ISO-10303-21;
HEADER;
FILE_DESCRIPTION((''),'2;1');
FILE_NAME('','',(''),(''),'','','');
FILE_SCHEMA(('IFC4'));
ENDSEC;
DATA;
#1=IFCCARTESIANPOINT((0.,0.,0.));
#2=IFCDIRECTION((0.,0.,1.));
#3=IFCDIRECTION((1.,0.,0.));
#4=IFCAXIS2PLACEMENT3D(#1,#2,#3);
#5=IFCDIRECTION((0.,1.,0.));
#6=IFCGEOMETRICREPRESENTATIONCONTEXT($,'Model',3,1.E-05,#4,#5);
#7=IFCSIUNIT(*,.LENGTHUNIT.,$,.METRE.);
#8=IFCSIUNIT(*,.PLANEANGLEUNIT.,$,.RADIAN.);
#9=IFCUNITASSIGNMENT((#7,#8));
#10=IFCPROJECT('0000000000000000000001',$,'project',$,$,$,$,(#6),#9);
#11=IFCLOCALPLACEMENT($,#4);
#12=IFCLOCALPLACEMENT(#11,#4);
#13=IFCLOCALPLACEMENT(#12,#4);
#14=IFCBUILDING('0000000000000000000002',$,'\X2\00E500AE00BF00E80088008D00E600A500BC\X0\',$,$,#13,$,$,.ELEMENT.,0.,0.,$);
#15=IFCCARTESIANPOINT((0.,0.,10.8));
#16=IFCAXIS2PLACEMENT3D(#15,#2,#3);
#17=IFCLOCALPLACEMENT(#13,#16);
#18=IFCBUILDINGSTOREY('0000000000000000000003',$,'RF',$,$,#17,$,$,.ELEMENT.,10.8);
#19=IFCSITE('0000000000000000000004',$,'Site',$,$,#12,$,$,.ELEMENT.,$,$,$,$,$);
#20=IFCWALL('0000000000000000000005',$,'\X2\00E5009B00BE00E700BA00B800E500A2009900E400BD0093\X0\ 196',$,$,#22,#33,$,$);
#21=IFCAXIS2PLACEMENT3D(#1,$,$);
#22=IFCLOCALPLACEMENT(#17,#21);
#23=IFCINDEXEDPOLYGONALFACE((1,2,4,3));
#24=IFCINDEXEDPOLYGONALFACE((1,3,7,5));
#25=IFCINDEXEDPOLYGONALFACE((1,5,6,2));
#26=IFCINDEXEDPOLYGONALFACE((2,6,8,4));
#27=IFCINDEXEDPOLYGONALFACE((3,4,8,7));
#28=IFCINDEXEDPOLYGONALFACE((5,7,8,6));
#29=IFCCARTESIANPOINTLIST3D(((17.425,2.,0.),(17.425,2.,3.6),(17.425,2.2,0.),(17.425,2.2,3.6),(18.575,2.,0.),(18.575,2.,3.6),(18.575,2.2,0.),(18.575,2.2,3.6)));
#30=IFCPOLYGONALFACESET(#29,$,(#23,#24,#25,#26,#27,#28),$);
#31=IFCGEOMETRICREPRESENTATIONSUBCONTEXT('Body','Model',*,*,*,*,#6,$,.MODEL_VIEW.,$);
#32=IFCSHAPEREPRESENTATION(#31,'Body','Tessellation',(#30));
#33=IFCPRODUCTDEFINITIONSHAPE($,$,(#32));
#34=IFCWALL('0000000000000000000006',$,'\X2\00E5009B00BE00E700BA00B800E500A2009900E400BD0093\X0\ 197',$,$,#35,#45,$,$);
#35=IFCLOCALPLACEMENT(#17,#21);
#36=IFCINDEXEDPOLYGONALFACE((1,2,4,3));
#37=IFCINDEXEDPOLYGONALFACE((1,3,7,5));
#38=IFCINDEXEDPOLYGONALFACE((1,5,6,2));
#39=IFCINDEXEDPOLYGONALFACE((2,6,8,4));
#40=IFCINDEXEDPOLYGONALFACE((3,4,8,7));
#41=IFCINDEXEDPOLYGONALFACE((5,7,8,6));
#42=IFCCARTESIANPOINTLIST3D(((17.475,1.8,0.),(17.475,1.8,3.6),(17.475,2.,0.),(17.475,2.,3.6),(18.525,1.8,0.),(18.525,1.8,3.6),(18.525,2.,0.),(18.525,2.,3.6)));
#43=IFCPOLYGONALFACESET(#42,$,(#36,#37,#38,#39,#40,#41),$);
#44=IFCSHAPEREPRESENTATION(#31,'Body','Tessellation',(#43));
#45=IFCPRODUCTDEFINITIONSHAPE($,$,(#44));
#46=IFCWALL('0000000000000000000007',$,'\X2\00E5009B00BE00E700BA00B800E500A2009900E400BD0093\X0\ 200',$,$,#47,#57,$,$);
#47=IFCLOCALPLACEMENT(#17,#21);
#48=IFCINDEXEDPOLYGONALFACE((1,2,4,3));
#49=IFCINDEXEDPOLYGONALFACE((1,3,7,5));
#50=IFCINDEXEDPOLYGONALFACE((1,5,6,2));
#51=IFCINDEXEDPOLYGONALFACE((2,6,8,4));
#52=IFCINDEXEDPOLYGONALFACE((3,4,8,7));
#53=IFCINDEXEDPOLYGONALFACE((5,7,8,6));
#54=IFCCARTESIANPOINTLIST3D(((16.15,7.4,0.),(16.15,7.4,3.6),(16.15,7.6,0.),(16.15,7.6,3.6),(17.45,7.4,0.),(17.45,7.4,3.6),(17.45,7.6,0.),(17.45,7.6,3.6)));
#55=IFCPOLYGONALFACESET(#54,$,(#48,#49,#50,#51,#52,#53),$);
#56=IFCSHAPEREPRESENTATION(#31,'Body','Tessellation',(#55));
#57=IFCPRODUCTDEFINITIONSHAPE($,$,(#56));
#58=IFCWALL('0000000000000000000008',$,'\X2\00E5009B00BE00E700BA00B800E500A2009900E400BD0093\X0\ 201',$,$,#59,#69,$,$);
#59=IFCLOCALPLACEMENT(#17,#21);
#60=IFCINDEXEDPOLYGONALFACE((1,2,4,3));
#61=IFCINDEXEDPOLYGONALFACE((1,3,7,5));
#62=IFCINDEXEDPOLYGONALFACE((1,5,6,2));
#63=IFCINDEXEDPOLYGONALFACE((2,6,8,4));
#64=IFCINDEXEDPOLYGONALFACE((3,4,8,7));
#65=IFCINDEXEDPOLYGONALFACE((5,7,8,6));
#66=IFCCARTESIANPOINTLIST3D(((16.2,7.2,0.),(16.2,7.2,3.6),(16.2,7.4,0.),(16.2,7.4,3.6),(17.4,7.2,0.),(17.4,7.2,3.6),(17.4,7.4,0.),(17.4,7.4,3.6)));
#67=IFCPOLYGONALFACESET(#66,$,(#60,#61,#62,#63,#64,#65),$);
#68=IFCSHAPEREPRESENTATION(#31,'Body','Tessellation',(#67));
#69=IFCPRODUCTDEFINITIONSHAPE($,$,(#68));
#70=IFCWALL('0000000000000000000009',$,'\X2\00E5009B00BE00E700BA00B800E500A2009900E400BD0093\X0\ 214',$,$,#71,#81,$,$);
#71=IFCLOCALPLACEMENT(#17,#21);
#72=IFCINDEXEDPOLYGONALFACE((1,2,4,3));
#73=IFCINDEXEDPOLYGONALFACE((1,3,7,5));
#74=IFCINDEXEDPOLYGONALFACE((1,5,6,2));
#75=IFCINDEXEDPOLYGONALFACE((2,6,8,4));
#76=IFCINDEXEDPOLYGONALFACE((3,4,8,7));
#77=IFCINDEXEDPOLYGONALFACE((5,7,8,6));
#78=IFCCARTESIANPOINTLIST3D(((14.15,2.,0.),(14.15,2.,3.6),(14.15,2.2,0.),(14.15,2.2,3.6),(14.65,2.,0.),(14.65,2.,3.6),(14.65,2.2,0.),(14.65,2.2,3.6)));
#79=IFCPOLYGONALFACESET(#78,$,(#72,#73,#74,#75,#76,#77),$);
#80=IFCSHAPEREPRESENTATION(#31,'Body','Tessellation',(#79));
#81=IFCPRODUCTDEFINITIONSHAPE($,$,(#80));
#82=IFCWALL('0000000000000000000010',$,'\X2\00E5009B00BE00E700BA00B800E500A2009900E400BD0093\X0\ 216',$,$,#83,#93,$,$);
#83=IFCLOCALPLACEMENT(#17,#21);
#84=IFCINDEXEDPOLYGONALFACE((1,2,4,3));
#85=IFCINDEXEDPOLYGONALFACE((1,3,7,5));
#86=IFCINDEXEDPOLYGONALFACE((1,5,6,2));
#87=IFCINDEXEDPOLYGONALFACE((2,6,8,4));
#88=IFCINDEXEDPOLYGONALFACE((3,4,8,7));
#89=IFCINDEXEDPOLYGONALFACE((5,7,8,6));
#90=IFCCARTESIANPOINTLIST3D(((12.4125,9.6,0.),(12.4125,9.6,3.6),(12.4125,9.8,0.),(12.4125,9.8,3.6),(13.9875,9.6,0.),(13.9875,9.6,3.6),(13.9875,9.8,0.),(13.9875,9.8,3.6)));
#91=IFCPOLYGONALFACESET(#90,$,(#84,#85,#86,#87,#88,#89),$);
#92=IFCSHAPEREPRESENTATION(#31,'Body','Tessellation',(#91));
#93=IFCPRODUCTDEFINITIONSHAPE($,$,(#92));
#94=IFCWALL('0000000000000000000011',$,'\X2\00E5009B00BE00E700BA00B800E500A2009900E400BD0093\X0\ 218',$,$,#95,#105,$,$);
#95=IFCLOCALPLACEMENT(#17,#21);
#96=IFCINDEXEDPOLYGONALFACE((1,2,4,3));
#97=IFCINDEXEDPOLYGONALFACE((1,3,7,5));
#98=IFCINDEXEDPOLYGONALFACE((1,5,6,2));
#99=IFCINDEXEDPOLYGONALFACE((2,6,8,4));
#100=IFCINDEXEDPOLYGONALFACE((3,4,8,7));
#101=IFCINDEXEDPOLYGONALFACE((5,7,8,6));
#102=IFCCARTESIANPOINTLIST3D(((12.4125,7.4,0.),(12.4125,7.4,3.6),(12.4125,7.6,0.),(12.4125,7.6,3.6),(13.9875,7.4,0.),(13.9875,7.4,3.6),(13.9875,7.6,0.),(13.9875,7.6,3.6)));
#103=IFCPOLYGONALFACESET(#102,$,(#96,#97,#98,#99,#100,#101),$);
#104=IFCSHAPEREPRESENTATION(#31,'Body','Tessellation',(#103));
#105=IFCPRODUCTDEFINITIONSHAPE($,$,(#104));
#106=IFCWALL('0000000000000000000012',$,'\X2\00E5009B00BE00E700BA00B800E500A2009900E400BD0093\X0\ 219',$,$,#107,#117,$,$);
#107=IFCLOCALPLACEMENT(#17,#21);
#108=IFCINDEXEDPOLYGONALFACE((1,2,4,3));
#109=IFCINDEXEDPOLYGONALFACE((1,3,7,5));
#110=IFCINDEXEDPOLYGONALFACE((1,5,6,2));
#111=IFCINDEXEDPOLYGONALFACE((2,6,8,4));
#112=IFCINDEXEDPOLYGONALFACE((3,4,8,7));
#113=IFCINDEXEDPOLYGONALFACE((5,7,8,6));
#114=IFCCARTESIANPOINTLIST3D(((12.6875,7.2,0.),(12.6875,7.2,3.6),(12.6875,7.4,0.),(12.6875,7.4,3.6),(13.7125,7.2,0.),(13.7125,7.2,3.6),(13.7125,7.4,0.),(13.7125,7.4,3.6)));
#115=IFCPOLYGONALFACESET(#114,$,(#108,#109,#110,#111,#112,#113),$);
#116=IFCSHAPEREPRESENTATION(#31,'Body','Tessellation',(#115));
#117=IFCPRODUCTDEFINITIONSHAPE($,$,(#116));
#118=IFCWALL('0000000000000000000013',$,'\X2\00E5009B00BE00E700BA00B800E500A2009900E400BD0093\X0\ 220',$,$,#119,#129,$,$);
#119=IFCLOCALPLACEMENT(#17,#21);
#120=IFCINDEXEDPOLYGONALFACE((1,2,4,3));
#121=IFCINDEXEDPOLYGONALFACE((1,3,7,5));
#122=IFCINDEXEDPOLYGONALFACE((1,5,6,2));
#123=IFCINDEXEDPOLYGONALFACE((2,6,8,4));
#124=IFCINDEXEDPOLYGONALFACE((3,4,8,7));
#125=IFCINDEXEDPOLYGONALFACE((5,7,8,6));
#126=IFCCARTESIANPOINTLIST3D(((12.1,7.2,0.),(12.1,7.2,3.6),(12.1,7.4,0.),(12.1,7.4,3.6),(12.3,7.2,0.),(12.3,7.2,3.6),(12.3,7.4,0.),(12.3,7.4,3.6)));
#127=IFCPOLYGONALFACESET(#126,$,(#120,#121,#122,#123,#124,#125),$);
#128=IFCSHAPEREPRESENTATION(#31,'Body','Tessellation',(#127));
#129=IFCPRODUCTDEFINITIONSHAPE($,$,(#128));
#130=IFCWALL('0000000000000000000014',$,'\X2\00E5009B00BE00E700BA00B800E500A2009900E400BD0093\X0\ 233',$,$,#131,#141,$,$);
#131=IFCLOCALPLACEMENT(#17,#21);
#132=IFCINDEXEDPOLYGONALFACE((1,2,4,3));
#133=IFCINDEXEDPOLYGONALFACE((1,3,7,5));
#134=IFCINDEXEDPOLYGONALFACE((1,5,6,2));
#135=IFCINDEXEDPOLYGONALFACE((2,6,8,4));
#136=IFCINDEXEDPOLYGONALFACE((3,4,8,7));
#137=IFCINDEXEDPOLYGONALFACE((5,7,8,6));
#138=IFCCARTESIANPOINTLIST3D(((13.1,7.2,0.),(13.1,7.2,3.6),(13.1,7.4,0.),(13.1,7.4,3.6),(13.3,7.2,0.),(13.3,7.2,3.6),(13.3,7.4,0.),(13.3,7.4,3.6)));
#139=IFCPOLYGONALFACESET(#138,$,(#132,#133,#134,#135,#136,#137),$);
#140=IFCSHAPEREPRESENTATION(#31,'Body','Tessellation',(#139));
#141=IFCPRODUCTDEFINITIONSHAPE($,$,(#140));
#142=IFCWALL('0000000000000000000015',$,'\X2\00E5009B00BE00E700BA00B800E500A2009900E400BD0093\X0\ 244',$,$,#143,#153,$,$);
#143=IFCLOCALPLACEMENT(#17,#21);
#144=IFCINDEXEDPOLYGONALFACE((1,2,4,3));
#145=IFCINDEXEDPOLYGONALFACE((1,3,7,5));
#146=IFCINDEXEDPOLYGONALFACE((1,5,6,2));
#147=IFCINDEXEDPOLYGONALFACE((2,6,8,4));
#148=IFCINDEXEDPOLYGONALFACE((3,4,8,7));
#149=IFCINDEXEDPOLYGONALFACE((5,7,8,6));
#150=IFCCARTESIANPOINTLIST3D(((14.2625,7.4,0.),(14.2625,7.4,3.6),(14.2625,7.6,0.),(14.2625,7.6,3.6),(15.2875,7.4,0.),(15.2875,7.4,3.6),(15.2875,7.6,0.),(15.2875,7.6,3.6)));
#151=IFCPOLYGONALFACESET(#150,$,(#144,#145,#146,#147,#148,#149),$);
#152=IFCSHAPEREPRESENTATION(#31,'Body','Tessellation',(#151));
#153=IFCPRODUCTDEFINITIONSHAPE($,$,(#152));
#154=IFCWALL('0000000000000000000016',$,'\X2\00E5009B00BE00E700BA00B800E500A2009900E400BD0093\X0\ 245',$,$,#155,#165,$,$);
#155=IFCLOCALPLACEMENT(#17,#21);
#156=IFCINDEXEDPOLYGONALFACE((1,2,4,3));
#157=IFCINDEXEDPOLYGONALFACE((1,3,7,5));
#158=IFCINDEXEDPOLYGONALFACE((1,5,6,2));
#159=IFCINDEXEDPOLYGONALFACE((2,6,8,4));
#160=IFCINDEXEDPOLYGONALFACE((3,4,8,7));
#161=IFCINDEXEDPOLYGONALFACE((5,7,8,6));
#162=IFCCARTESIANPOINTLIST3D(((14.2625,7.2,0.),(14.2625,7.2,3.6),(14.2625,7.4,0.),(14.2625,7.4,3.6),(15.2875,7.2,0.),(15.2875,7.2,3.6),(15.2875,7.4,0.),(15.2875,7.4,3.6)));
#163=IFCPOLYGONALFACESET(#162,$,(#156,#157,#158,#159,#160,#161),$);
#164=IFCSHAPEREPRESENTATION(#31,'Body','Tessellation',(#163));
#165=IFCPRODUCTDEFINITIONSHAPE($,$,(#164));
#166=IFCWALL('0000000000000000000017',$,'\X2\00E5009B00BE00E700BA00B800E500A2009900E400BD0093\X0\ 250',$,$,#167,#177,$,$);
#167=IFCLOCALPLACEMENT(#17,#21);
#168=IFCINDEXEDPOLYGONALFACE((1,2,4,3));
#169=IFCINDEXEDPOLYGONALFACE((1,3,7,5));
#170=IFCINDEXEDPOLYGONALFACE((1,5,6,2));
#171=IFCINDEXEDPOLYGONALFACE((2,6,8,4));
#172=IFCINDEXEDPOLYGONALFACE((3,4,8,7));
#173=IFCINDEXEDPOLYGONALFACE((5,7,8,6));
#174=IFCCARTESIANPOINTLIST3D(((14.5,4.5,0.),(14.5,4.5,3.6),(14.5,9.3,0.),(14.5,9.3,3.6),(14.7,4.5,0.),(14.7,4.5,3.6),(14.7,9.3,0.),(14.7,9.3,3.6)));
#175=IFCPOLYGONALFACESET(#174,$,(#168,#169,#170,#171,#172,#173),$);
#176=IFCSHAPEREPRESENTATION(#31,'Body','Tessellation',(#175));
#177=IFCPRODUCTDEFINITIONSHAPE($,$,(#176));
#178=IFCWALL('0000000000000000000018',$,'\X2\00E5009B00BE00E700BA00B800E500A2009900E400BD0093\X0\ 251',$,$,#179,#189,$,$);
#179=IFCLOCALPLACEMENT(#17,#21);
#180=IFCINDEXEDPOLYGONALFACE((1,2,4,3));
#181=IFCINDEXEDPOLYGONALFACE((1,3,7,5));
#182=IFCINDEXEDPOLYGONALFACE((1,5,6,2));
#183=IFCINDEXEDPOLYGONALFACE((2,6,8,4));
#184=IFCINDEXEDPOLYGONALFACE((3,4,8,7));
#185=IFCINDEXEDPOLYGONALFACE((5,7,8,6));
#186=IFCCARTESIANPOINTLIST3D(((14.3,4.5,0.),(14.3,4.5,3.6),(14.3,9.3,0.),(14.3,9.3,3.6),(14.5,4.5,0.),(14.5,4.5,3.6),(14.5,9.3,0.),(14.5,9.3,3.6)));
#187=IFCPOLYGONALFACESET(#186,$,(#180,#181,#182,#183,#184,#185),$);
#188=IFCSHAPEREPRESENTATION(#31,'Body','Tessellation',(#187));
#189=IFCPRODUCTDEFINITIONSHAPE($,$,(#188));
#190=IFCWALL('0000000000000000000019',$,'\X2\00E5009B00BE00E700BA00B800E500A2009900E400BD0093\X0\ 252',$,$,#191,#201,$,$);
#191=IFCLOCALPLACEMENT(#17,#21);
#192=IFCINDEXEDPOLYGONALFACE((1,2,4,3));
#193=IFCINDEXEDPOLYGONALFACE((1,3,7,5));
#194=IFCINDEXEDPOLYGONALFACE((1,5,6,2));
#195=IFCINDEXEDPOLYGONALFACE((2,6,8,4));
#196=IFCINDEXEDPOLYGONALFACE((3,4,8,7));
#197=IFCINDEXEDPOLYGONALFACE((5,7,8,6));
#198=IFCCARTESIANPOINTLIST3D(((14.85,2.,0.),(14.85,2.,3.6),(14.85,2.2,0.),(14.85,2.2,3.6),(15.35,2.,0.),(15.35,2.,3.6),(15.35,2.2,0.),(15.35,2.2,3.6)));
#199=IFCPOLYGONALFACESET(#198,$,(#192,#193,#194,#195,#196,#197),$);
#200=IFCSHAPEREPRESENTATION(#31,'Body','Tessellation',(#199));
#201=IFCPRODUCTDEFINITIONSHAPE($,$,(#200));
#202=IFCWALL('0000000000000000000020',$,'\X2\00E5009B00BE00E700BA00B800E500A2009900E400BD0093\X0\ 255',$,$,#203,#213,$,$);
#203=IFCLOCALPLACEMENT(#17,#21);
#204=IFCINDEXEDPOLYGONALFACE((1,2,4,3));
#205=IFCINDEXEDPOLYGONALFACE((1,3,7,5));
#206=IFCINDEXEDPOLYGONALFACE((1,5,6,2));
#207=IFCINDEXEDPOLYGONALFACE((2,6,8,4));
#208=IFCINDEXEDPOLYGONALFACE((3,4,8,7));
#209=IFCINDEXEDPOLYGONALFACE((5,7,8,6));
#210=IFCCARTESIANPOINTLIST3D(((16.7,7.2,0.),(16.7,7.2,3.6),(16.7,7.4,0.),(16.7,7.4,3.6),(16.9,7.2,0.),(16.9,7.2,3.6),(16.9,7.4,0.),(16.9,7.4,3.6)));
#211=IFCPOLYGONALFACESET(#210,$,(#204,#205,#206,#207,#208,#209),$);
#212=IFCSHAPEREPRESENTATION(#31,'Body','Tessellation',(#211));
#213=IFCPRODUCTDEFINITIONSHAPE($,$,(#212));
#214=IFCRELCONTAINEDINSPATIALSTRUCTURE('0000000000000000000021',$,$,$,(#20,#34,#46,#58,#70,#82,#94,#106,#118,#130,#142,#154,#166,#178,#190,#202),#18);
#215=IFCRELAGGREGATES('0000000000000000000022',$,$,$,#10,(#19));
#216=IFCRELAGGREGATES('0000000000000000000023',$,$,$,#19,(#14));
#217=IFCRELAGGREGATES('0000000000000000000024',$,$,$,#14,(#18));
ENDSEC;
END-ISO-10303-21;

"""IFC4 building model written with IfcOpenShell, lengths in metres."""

from ifc_helpers import new_model, si_unit, direction, frame, frame_2d, origin_with_axes, place, context, subcontext, project, spatial, rectangle, extrude, element, save


model = new_model("IFC4")

# Units and contexts
model_context = context("Model", 3, precision=1e-05, world=origin_with_axes(), true_north=direction((0.0, 1.0, 0.0)))
body_context = subcontext(model_context, "Body", "Model", "MODEL_VIEW")
ifc_project = project(units=[si_unit("LENGTHUNIT", "METRE"), si_unit("PLANEANGLEUNIT", "RADIAN")], contexts=[model_context])

# Site, building, storey
placement = place(None, origin_with_axes())
site_placement = place(placement, origin_with_axes())
site = spatial("IfcSite", under=ifc_project, at=site_placement, Name="Site", CompositionType="ELEMENT")
building_placement = place(site_placement, origin_with_axes())
building = spatial("IfcBuilding", under=site, at=building_placement, Name="å®¿è\u0088\u008dæ¥¼", CompositionType="ELEMENT", ElevationOfRefHeight=0.0, ElevationOfTerrain=0.0)
storey_placement = place(building_placement, frame((0.0, 0.0, 10.8), z_axis=(0.0, 0.0, 1.0), x_axis=(1.0, 0.0, 0.0)))
storey = spatial("IfcBuildingStorey", under=building, at=storey_placement, Name="RF", CompositionType="ELEMENT", Elevation=10.8)

# Walls
wall_1_placement = place(storey_placement, frame((18.0, 2.1, 0.0), z_axis=(0.0, 0.0, 1.0), x_axis=(-1.0, 0.0, 0.0)))
element("IfcWall", 1, at=wall_1_placement, inside=storey, Name="å\u009b¾çº¸å¢\u0099ä½\u0093 196", context=body_context, shape_type="SweptSolid", body=[
    extrude(rectangle(XDim=1.15, YDim=0.2, at=frame_2d((0.0, 0.0), x_axis=(1.0, 0.0, 0.0))), frame((0.0, 0.0, 0.0), z_axis=(0.0, 0.0, 1.0)), (0.0, 0.0, 1.0), 3.6),
])
wall_2_placement = place(storey_placement, frame((18.0, 1.9, 0.0), z_axis=(0.0, 0.0, 1.0), x_axis=(-1.0, 0.0, 0.0)))
element("IfcWall", 2, at=wall_2_placement, inside=storey, Name="å\u009b¾çº¸å¢\u0099ä½\u0093 197", context=body_context, shape_type="SweptSolid", body=[
    extrude(rectangle(XDim=1.05, YDim=0.2, at=frame_2d((0.0, 0.0), x_axis=(1.0, 0.0, 0.0))), frame((0.0, 0.0, 0.0), z_axis=(0.0, 0.0, 1.0)), (0.0, 0.0, 1.0), 3.6),
])
wall_3_placement = place(storey_placement, frame((16.8, 7.5, 0.0), z_axis=(0.0, 0.0, 1.0), x_axis=(1.0, 0.0, 0.0)))
element("IfcWall", 3, at=wall_3_placement, inside=storey, Name="å\u009b¾çº¸å¢\u0099ä½\u0093 200", context=body_context, shape_type="SweptSolid", body=[
    extrude(rectangle(XDim=1.3, YDim=0.2, at=frame_2d((0.0, 0.0), x_axis=(1.0, 0.0, 0.0))), frame((0.0, 0.0, 0.0), z_axis=(0.0, 0.0, 1.0)), (0.0, 0.0, 1.0), 3.6),
])
wall_4_placement = place(storey_placement, frame((16.8, 7.3, 0.0), z_axis=(0.0, 0.0, 1.0), x_axis=(1.0, 0.0, 0.0)))
element("IfcWall", 4, at=wall_4_placement, inside=storey, Name="å\u009b¾çº¸å¢\u0099ä½\u0093 201", context=body_context, shape_type="SweptSolid", body=[
    extrude(rectangle(XDim=1.2, YDim=0.2, at=frame_2d((0.0, 0.0), x_axis=(1.0, 0.0, 0.0))), frame((0.0, 0.0, 0.0), z_axis=(0.0, 0.0, 1.0)), (0.0, 0.0, 1.0), 3.6),
])
wall_5_placement = place(storey_placement, frame((14.4, 2.1, 0.0), z_axis=(0.0, 0.0, 1.0), x_axis=(-1.0, 0.0, 0.0)))
element("IfcWall", 5, at=wall_5_placement, inside=storey, Name="å\u009b¾çº¸å¢\u0099ä½\u0093 214", context=body_context, shape_type="SweptSolid", body=[
    extrude(rectangle(XDim=0.5, YDim=0.2, at=frame_2d((0.0, 0.0), x_axis=(1.0, 0.0, 0.0))), frame((0.0, 0.0, 0.0), z_axis=(0.0, 0.0, 1.0)), (0.0, 0.0, 1.0), 3.6),
])
for number, where, z_axis, x_axis, name in (
    (6, (13.2, 9.7, 0.0), (0.0, 0.0, 1.0), (1.0, 0.0, 0.0), "å\u009b¾çº¸å¢\u0099ä½\u0093 216"),
    (7, (13.2, 7.5, 0.0), (0.0, 0.0, 1.0), (1.0, 0.0, 0.0), "å\u009b¾çº¸å¢\u0099ä½\u0093 218"),
):
    element("IfcWall", number, at=place(storey_placement, frame(where, z_axis=z_axis, x_axis=x_axis)), inside=storey, Name=name, context=body_context, shape_type="SweptSolid", body=[
        extrude(rectangle(XDim=1.575, YDim=0.2, at=frame_2d((0.0, 0.0), x_axis=(1.0, 0.0, 0.0))), frame((0.0, 0.0, 0.0), z_axis=(0.0, 0.0, 1.0)), (0.0, 0.0, 1.0), 3.6),
    ])
wall_6_placement = place(storey_placement, frame((13.2, 7.3, 0.0), z_axis=(0.0, 0.0, 1.0), x_axis=(1.0, 0.0, 0.0)))
element("IfcWall", 8, at=wall_6_placement, inside=storey, Name="å\u009b¾çº¸å¢\u0099ä½\u0093 219", context=body_context, shape_type="SweptSolid", body=[
    extrude(rectangle(XDim=1.025, YDim=0.2, at=frame_2d((0.0, 0.0), x_axis=(1.0, 0.0, 0.0))), frame((0.0, 0.0, 0.0), z_axis=(0.0, 0.0, 1.0)), (0.0, 0.0, 1.0), 3.6),
])
for number, where, z_axis, x_axis, name in (
    (9, (12.2, 7.3, 0.0), (0.0, 0.0, 1.0), (0.0, 1.0, 0.0), "å\u009b¾çº¸å¢\u0099ä½\u0093 220"),
    (10, (13.2, 7.3, 0.0), (0.0, 0.0, 1.0), (0.0, 1.0, 0.0), "å\u009b¾çº¸å¢\u0099ä½\u0093 233"),
):
    element("IfcWall", number, at=place(storey_placement, frame(where, z_axis=z_axis, x_axis=x_axis)), inside=storey, Name=name, context=body_context, shape_type="SweptSolid", body=[
        extrude(rectangle(XDim=0.2, YDim=0.2, at=frame_2d((0.0, 0.0), x_axis=(1.0, 0.0, 0.0))), frame((0.0, 0.0, 0.0), z_axis=(0.0, 0.0, 1.0)), (0.0, 0.0, 1.0), 3.6),
    ])
for number, where, z_axis, x_axis, name in (
    (11, (14.775, 7.5, 0.0), (0.0, 0.0, 1.0), (1.0, 0.0, 0.0), "å\u009b¾çº¸å¢\u0099ä½\u0093 244"),
    (12, (14.775, 7.3, 0.0), (0.0, 0.0, 1.0), (1.0, 0.0, 0.0), "å\u009b¾çº¸å¢\u0099ä½\u0093 245"),
):
    element("IfcWall", number, at=place(storey_placement, frame(where, z_axis=z_axis, x_axis=x_axis)), inside=storey, Name=name, context=body_context, shape_type="SweptSolid", body=[
        extrude(rectangle(XDim=1.025, YDim=0.2, at=frame_2d((0.0, 0.0), x_axis=(1.0, 0.0, 0.0))), frame((0.0, 0.0, 0.0), z_axis=(0.0, 0.0, 1.0)), (0.0, 0.0, 1.0), 3.6),
    ])
for number, where, z_axis, x_axis, name in (
    (13, (14.6, 6.9, 0.0), (0.0, 0.0, 1.0), (0.0, -1.0, 0.0), "å\u009b¾çº¸å¢\u0099ä½\u0093 250"),
    (14, (14.4, 6.9, 0.0), (0.0, 0.0, 1.0), (0.0, -1.0, 0.0), "å\u009b¾çº¸å¢\u0099ä½\u0093 251"),
):
    element("IfcWall", number, at=place(storey_placement, frame(where, z_axis=z_axis, x_axis=x_axis)), inside=storey, Name=name, context=body_context, shape_type="SweptSolid", body=[
        extrude(rectangle(XDim=4.8, YDim=0.2, at=frame_2d((0.0, 0.0), x_axis=(1.0, 0.0, 0.0))), frame((0.0, 0.0, 0.0), z_axis=(0.0, 0.0, 1.0)), (0.0, 0.0, 1.0), 3.6),
    ])
wall_7_placement = place(storey_placement, frame((15.1, 2.1, 0.0), z_axis=(0.0, 0.0, 1.0), x_axis=(-1.0, 0.0, 0.0)))
element("IfcWall", 15, at=wall_7_placement, inside=storey, Name="å\u009b¾çº¸å¢\u0099ä½\u0093 252", context=body_context, shape_type="SweptSolid", body=[
    extrude(rectangle(XDim=0.5, YDim=0.2, at=frame_2d((0.0, 0.0), x_axis=(1.0, 0.0, 0.0))), frame((0.0, 0.0, 0.0), z_axis=(0.0, 0.0, 1.0)), (0.0, 0.0, 1.0), 3.6),
])
for number, where, z_axis, x_axis, name in (
    (16, (16.8, 7.3, 0.0), (0.0, 0.0, 1.0), (0.0, 1.0, 0.0), "å\u009b¾çº¸å¢\u0099ä½\u0093 255"),
):
    element("IfcWall", number, at=place(storey_placement, frame(where, z_axis=z_axis, x_axis=x_axis)), inside=storey, Name=name, context=body_context, shape_type="SweptSolid", body=[
        extrude(rectangle(XDim=0.2, YDim=0.2, at=frame_2d((0.0, 0.0), x_axis=(1.0, 0.0, 0.0))), frame((0.0, 0.0, 0.0), z_axis=(0.0, 0.0, 1.0)), (0.0, 0.0, 1.0), 3.6),
    ])

save(model, "model.ifc")
